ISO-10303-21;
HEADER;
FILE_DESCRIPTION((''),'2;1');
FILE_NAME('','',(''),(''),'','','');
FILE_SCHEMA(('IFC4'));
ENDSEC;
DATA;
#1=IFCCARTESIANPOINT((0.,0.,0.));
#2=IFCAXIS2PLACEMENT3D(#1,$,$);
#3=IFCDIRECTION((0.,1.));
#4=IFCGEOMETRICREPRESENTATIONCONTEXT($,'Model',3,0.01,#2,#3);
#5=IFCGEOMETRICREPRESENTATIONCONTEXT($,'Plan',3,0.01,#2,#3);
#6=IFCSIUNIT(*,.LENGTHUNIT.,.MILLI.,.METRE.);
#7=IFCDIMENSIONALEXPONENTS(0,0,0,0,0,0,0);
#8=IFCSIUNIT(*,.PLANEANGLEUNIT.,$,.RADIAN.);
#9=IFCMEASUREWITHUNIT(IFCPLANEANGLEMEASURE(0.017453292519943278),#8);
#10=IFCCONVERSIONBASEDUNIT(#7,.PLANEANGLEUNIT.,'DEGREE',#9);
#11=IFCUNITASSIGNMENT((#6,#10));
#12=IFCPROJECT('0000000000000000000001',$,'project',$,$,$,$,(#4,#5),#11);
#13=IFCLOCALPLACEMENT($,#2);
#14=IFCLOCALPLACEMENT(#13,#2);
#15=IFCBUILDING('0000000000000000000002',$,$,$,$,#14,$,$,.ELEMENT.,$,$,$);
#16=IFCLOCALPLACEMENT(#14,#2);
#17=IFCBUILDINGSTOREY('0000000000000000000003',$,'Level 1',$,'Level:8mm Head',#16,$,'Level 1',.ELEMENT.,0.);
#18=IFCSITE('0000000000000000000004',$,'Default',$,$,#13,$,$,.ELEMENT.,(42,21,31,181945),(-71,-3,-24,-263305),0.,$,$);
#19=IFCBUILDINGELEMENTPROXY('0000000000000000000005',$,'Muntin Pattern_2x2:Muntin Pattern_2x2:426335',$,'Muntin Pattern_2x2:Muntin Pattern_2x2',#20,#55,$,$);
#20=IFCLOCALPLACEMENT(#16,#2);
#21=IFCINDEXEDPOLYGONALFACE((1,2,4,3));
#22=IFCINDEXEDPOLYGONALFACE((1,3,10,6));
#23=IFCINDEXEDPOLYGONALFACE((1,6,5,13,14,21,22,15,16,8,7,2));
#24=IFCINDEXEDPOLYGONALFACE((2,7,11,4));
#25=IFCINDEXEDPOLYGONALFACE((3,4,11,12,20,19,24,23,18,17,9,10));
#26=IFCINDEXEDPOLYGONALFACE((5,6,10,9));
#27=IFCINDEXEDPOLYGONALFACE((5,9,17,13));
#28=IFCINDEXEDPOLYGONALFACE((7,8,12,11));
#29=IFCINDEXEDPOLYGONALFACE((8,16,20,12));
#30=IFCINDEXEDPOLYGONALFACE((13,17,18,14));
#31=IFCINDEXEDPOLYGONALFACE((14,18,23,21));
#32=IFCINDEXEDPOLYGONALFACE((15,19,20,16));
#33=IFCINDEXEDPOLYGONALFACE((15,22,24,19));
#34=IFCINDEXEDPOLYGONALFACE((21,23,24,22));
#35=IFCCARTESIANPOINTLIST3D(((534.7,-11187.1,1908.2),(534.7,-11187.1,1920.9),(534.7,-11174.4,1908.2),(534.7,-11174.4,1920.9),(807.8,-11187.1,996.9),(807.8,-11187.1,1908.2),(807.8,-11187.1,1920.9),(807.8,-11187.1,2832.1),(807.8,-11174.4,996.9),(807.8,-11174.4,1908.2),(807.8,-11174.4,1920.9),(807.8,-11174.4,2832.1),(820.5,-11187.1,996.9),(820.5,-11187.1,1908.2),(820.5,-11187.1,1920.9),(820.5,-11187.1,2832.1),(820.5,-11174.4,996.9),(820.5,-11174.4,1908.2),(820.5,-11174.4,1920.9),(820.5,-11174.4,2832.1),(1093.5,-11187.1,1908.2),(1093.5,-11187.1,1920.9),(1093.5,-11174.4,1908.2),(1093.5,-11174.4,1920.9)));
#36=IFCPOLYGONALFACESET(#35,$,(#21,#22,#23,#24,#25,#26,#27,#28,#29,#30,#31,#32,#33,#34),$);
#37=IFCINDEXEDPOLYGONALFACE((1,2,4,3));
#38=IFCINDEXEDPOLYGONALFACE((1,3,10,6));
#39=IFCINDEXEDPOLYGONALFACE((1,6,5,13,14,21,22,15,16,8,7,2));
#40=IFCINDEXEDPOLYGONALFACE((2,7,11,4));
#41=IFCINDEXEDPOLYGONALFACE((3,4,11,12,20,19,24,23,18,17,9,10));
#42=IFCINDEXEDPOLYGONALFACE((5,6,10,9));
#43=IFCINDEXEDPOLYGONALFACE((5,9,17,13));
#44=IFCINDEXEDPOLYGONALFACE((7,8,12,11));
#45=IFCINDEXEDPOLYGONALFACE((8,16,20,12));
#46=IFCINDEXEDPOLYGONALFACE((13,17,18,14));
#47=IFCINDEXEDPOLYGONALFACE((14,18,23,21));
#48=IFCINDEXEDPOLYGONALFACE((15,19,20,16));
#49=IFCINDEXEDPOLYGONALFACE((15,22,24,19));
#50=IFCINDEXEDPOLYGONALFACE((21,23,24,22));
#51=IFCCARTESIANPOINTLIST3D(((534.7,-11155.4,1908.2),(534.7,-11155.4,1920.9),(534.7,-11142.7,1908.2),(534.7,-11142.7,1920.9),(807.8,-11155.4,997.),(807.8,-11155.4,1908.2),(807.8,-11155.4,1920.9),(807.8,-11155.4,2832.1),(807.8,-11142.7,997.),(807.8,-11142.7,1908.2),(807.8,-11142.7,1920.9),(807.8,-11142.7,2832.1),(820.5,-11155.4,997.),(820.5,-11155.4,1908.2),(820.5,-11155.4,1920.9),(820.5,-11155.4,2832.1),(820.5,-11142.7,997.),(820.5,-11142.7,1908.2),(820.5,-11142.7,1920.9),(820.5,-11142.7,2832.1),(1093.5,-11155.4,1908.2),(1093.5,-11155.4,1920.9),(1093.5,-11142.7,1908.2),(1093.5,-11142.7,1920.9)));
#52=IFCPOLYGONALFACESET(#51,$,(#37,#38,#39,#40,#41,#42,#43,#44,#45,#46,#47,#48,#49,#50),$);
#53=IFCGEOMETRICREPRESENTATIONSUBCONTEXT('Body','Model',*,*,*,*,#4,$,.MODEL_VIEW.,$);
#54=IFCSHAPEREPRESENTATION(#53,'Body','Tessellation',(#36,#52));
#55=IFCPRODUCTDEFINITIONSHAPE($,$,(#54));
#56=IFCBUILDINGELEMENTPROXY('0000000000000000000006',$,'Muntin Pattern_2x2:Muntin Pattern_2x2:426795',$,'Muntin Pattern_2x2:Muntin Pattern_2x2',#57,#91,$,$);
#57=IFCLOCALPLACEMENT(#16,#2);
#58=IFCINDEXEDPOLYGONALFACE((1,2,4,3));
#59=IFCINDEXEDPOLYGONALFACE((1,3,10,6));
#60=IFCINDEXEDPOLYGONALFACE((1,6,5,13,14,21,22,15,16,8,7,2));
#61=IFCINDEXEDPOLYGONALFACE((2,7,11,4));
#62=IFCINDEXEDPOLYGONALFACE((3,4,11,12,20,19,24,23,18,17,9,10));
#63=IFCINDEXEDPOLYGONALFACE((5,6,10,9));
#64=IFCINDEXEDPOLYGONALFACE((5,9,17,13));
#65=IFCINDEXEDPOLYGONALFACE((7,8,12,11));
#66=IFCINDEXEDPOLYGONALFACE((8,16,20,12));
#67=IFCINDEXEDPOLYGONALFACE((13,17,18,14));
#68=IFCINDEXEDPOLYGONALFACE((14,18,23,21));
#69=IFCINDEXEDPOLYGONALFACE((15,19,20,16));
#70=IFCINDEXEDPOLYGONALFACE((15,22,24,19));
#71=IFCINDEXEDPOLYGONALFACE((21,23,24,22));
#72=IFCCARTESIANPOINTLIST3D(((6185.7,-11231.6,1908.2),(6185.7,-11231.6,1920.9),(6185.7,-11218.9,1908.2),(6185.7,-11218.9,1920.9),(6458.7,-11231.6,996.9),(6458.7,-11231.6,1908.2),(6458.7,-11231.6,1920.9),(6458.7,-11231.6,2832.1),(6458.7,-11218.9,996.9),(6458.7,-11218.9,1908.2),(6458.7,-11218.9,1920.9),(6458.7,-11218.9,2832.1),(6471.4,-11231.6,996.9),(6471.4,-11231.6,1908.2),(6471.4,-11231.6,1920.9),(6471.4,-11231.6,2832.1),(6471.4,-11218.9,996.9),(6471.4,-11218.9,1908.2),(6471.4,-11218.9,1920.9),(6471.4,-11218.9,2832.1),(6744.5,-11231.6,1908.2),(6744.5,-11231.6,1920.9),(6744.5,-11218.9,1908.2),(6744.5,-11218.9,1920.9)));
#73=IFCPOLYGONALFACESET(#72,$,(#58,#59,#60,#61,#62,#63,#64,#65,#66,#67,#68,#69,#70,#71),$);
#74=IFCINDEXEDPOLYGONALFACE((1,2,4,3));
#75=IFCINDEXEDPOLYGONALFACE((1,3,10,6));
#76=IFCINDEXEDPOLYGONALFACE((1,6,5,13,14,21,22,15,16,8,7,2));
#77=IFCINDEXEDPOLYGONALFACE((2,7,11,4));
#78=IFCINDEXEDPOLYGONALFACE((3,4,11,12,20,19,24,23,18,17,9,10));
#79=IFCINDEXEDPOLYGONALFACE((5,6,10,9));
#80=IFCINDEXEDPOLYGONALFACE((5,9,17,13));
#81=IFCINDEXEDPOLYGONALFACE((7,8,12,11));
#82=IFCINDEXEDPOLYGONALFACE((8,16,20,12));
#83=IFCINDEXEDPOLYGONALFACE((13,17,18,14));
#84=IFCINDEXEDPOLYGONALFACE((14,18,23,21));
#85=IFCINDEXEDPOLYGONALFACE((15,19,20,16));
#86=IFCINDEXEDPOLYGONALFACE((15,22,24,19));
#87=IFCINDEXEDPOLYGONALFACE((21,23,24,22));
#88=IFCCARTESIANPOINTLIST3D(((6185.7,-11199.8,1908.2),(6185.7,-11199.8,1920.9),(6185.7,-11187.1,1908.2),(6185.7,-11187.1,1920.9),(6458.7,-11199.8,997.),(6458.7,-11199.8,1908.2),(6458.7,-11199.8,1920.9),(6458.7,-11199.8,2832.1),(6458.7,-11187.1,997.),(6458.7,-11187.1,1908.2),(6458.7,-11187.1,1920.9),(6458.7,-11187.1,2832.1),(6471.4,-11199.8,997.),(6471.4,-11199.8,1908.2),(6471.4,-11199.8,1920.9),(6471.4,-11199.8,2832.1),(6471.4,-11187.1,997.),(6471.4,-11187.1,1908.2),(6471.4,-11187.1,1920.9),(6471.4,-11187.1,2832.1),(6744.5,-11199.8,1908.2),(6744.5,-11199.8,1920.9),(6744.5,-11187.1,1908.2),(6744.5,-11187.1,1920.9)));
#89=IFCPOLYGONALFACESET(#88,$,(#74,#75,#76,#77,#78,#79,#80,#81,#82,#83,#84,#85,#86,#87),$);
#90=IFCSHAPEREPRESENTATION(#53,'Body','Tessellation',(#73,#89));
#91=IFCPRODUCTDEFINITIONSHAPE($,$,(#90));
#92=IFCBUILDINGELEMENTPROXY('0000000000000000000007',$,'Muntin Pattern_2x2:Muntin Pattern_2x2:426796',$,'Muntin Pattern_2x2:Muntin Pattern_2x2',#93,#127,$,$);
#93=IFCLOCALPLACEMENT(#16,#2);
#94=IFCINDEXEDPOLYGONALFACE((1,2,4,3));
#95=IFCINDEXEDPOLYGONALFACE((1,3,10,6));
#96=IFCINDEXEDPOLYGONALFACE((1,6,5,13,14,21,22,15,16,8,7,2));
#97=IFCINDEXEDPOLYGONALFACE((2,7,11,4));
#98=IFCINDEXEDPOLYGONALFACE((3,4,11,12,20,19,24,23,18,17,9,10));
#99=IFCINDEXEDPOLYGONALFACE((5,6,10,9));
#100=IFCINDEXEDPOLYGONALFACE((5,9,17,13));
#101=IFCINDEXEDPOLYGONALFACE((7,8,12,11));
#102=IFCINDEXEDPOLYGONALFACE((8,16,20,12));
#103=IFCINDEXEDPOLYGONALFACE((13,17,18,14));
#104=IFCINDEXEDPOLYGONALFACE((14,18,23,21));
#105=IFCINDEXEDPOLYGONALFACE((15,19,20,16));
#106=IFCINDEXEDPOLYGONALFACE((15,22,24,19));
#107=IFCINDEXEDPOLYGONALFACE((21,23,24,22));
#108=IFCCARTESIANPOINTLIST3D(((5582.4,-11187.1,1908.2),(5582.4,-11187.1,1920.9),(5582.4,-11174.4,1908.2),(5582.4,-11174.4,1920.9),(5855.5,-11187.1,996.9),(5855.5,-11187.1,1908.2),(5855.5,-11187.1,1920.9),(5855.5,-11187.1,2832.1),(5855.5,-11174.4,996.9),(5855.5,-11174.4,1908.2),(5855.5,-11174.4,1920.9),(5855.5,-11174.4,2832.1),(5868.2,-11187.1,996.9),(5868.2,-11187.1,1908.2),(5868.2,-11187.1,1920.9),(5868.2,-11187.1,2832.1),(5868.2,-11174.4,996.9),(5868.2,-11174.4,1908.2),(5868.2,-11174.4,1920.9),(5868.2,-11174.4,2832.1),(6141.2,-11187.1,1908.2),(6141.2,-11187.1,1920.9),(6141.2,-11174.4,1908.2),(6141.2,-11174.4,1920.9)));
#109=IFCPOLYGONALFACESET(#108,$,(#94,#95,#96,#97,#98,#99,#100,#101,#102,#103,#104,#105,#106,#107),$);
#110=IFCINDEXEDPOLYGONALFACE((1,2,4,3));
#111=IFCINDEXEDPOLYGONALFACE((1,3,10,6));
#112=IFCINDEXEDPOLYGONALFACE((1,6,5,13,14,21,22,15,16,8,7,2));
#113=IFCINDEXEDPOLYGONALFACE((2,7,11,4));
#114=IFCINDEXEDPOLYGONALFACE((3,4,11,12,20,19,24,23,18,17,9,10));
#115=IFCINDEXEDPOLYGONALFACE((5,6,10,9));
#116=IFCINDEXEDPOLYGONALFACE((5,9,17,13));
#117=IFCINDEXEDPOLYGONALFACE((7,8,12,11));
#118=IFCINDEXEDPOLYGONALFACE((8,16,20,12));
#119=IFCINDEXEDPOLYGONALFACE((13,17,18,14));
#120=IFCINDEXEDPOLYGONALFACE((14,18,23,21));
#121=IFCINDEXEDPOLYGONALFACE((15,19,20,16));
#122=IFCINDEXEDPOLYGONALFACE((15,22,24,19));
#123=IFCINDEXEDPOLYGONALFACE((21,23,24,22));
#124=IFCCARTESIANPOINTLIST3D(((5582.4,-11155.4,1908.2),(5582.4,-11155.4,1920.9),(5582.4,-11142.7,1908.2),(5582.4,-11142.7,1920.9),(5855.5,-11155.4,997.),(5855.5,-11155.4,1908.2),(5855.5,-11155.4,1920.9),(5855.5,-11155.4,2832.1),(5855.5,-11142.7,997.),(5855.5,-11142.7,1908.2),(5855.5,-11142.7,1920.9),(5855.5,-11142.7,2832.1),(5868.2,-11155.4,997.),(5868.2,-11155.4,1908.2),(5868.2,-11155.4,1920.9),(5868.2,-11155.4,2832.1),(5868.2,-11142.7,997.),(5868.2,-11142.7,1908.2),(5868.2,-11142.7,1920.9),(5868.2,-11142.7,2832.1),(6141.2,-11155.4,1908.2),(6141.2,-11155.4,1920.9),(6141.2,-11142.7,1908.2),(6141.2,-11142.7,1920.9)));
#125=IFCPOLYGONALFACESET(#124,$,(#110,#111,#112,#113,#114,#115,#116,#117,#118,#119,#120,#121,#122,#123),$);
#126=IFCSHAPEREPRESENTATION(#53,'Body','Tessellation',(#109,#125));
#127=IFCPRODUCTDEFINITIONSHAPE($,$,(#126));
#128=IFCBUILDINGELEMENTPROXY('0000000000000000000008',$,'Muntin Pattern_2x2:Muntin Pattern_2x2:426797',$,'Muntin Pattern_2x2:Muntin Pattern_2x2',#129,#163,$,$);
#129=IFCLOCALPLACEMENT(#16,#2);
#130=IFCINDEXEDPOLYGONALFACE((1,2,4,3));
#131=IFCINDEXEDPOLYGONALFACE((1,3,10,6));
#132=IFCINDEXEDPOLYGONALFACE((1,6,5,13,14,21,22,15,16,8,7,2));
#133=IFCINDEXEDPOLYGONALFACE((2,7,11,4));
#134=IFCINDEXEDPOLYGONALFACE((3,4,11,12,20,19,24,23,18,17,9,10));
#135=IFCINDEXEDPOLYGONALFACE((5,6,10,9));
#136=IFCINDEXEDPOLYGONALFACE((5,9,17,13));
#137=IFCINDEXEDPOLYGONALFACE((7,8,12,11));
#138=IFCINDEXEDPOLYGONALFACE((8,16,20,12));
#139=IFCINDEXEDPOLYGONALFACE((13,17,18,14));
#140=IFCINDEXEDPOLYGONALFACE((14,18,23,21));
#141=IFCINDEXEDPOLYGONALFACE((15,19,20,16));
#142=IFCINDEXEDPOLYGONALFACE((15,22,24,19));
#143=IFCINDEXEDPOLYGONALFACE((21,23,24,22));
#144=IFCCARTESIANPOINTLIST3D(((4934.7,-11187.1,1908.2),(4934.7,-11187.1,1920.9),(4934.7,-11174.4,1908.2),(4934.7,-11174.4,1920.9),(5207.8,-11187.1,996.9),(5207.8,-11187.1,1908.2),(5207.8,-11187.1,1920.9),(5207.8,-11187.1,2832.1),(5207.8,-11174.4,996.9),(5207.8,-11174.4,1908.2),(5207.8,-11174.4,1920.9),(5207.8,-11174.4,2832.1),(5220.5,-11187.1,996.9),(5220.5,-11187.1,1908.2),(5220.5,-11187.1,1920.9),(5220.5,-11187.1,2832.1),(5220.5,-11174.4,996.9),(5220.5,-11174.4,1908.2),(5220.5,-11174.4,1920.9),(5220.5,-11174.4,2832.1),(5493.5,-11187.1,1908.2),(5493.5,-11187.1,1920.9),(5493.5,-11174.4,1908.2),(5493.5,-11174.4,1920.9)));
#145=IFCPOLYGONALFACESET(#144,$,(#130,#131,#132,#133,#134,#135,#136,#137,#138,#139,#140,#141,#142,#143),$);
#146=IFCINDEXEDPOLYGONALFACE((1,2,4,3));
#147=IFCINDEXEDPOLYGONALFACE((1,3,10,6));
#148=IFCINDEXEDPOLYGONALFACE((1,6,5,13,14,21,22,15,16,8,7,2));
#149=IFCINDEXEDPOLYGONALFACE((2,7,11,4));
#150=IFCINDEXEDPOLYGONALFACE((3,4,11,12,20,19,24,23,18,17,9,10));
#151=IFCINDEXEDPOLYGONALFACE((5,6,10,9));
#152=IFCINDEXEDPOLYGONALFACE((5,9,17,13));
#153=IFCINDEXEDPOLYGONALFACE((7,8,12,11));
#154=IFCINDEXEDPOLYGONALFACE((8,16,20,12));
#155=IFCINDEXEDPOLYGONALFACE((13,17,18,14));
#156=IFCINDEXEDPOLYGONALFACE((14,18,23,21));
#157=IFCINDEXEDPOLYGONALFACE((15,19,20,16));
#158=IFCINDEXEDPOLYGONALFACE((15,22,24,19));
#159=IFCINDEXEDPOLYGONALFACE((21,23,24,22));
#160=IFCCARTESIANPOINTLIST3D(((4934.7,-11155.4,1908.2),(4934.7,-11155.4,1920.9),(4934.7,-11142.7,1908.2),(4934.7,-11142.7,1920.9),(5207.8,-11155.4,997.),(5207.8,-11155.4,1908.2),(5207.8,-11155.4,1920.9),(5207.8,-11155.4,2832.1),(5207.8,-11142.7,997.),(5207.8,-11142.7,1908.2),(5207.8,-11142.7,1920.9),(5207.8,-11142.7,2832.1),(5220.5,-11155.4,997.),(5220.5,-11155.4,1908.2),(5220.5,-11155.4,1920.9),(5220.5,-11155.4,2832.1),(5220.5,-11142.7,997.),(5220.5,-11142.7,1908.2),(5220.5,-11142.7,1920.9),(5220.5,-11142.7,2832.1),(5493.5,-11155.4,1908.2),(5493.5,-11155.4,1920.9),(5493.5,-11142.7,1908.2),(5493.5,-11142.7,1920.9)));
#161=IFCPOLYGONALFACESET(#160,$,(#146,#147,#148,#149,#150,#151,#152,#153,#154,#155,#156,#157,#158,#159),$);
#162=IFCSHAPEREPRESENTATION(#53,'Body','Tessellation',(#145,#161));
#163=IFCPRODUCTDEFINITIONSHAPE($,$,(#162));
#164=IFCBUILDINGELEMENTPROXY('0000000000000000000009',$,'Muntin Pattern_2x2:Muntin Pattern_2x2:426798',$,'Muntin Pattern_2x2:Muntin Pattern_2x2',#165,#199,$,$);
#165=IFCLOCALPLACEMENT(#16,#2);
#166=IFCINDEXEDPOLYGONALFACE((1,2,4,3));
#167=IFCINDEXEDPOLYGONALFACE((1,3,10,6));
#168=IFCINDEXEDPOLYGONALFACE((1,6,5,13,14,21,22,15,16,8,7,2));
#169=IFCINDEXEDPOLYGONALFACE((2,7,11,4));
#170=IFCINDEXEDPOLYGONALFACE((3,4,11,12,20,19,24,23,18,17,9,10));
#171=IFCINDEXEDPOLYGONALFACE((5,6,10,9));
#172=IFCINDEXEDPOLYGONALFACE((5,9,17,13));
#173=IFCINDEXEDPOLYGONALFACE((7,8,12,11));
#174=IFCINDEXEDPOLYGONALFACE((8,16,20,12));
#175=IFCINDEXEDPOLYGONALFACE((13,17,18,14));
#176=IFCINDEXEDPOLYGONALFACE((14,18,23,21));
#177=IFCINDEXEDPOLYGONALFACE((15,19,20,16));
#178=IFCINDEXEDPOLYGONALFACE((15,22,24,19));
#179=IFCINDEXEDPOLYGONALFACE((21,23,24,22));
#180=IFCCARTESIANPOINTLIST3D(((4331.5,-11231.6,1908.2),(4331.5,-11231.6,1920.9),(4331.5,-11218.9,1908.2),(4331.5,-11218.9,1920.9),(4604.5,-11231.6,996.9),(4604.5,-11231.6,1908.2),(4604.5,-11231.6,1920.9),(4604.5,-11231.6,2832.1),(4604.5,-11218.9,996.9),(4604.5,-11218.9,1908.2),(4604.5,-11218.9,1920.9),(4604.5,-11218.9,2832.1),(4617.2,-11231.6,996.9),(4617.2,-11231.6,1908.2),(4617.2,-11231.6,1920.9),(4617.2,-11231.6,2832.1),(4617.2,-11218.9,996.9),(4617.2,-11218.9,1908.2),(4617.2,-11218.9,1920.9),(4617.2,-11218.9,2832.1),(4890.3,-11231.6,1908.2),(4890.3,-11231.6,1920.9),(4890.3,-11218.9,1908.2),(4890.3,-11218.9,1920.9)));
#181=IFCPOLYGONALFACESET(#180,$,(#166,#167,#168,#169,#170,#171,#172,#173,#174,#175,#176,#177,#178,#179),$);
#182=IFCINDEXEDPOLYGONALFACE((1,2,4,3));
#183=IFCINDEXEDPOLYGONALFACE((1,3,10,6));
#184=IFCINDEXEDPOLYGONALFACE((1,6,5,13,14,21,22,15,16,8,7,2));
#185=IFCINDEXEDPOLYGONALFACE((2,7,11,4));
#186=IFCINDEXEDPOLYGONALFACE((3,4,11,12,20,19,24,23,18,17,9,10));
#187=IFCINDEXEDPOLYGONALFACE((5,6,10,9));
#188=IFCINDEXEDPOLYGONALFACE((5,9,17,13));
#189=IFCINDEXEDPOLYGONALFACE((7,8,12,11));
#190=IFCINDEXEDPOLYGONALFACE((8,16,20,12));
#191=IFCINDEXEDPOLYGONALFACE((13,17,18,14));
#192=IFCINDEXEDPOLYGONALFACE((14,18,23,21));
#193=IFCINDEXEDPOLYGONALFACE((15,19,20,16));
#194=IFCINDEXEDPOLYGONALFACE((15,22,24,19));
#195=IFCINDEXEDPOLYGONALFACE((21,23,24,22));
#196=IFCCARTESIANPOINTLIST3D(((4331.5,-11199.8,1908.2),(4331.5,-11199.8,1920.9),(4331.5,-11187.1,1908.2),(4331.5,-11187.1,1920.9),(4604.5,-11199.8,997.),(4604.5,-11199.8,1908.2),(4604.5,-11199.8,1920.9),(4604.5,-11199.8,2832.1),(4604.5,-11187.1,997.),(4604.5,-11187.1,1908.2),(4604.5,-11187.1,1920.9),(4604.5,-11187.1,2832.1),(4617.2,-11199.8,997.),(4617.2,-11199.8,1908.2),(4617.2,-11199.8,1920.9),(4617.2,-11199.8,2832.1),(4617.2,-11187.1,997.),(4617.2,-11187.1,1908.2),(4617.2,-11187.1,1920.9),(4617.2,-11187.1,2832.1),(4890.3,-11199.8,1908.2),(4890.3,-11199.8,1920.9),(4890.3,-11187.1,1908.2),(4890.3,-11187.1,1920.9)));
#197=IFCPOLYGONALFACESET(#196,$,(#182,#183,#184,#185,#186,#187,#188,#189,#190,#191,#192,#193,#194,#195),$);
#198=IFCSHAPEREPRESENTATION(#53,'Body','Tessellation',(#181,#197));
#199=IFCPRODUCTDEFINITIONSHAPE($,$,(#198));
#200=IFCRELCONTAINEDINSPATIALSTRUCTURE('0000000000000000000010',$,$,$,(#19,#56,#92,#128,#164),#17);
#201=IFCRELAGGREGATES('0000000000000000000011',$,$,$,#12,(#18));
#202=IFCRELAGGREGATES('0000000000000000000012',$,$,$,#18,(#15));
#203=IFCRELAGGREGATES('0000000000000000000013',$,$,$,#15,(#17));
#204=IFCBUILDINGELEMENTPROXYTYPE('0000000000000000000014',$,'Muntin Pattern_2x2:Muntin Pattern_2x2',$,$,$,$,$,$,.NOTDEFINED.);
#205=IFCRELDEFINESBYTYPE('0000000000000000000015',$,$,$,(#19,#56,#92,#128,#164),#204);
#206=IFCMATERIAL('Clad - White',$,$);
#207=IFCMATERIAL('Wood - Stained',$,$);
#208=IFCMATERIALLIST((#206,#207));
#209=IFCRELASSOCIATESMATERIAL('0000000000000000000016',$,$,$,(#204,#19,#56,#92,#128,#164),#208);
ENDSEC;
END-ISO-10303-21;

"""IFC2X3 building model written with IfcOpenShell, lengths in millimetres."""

from ifc_helpers import new_model, entity, si_unit, converted_unit, direction, frame, origin, place, context, subcontext, project, spatial, polyline, outline, extrude, source, transform, mapped, material, material_list, type_object, type_shapes, element, save


model = new_model("IFC2X3")

# Units and contexts
model_context = context("Model", 3, precision=0.01, world=origin(), true_north=direction((0.0, 1.0)))
plan_context = context("Plan", 3, precision=0.01, world=origin(), true_north=direction((0.0, 1.0)))
body_context = subcontext(model_context, "Body", "Model", "MODEL_VIEW")
ifc_project = project(units=[si_unit("LENGTHUNIT", "METRE", prefix="MILLI"), converted_unit("PLANEANGLEUNIT", "DEGREE", entity("IfcPlaneAngleMeasure", 0.017453292519943278), si_unit("PLANEANGLEUNIT", "RADIAN"), dimensions=[0, 0, 0, 0, 0, 0, 0])], contexts=[model_context, plan_context])

# Site, building, storey
site_placement = place(None, origin())
site = spatial("IfcSite", under=ifc_project, at=site_placement, Name="Default", CompositionType="ELEMENT", RefLatitude=(42, 21, 31, 181945), RefLongitude=(-71, -3, -24, -263305), RefElevation=0.0)
building_placement = place(site_placement, origin())
building = spatial("IfcBuilding", under=site, at=building_placement, CompositionType="ELEMENT")
storey_placement = place(building_placement, origin())
storey = spatial("IfcBuildingStorey", under=building, at=storey_placement, Name="Level 1", ObjectType="Level:8mm Head", LongName="Level 1", CompositionType="ELEMENT", Elevation=0.0)

# Building element proxies
ifc_material_1 = material(Name="Clad - White")
ifc_material_2 = material(Name="Wood - Stained")
ifc_material_list_1 = material_list([ifc_material_1, ifc_material_2])
building_element_proxy_type_1 = type_object("IfcBuildingElementProxyType", Name="Muntin Pattern_2x2:Muntin Pattern_2x2", PredefinedType="NOTDEFINED", material=ifc_material_list_1)
shared_shape_1 = source(origin(), body_context, "Body", "SweptSolid", [
    extrude(outline(polyline([(6.4, -6.4), (917.6, -6.4), (917.6, 6.3), (6.4, 6.3), (6.4, 279.4), (-6.3, 279.4), (-6.3, 6.3), (-917.6, 6.3), (-917.6, -6.4), (-6.3, -6.4), (-6.3, -279.4), (6.4, -279.4), (6.4, -6.4)])), frame((0.0, 9.5, 917.6), z_axis=(0.0, 1.0, 0.0), x_axis=(0.0, 0.0, 1.0)), (0.0, 0.0, 1.0), 12.7),
    extrude(outline(polyline([(6.4, -6.4), (917.6, -6.4), (917.6, 6.3), (6.4, 6.3), (6.4, 279.4), (-6.3, 279.4), (-6.3, 6.3), (-917.6, 6.3), (-917.6, -6.4), (-6.3, -6.4), (-6.3, -279.4), (6.4, -279.4), (6.4, -6.4)])), frame((0.0, -22.2, 917.6), z_axis=(0.0, 1.0, 0.0), x_axis=(0.0, 0.0, 1.0)), (0.0, 0.0, 1.0), 12.7),
])
type_shapes(building_element_proxy_type_1, [shared_shape_1])
for number, where, z_axis, x_axis, name in (
    (1, (814.1, -11164.9, 997.0), (0.0, 0.0, 1.0), (-1.0, 0.0, 0.0), "Muntin Pattern_2x2:Muntin Pattern_2x2:426335"),
    (2, (6465.1, -11209.4, 997.0), (0.0, 0.0, 1.0), (-1.0, 0.0, 0.0), "Muntin Pattern_2x2:Muntin Pattern_2x2:426795"),
    (3, (5861.8, -11164.9, 997.0), (0.0, 0.0, 1.0), (-1.0, 0.0, 0.0), "Muntin Pattern_2x2:Muntin Pattern_2x2:426796"),
    (4, (5214.1, -11164.9, 997.0), (0.0, 0.0, 1.0), (-1.0, 0.0, 0.0), "Muntin Pattern_2x2:Muntin Pattern_2x2:426797"),
    (5, (4610.9, -11209.4, 997.0), (0.0, 0.0, 1.0), (-1.0, 0.0, 0.0), "Muntin Pattern_2x2:Muntin Pattern_2x2:426798"),
):
    element("IfcBuildingElementProxy", number, at=place(storey_placement, frame(where, z_axis=z_axis, x_axis=x_axis)), inside=storey, type_object=building_element_proxy_type_1, material=ifc_material_list_1, Name=name, ObjectType="Muntin Pattern_2x2:Muntin Pattern_2x2", context=body_context, shape_type="MappedRepresentation", body=[
        mapped(shared_shape_1, transform((0.0, 0.0, 0.0), scale=1.0)),
    ])

save(model, "model.ifc")
